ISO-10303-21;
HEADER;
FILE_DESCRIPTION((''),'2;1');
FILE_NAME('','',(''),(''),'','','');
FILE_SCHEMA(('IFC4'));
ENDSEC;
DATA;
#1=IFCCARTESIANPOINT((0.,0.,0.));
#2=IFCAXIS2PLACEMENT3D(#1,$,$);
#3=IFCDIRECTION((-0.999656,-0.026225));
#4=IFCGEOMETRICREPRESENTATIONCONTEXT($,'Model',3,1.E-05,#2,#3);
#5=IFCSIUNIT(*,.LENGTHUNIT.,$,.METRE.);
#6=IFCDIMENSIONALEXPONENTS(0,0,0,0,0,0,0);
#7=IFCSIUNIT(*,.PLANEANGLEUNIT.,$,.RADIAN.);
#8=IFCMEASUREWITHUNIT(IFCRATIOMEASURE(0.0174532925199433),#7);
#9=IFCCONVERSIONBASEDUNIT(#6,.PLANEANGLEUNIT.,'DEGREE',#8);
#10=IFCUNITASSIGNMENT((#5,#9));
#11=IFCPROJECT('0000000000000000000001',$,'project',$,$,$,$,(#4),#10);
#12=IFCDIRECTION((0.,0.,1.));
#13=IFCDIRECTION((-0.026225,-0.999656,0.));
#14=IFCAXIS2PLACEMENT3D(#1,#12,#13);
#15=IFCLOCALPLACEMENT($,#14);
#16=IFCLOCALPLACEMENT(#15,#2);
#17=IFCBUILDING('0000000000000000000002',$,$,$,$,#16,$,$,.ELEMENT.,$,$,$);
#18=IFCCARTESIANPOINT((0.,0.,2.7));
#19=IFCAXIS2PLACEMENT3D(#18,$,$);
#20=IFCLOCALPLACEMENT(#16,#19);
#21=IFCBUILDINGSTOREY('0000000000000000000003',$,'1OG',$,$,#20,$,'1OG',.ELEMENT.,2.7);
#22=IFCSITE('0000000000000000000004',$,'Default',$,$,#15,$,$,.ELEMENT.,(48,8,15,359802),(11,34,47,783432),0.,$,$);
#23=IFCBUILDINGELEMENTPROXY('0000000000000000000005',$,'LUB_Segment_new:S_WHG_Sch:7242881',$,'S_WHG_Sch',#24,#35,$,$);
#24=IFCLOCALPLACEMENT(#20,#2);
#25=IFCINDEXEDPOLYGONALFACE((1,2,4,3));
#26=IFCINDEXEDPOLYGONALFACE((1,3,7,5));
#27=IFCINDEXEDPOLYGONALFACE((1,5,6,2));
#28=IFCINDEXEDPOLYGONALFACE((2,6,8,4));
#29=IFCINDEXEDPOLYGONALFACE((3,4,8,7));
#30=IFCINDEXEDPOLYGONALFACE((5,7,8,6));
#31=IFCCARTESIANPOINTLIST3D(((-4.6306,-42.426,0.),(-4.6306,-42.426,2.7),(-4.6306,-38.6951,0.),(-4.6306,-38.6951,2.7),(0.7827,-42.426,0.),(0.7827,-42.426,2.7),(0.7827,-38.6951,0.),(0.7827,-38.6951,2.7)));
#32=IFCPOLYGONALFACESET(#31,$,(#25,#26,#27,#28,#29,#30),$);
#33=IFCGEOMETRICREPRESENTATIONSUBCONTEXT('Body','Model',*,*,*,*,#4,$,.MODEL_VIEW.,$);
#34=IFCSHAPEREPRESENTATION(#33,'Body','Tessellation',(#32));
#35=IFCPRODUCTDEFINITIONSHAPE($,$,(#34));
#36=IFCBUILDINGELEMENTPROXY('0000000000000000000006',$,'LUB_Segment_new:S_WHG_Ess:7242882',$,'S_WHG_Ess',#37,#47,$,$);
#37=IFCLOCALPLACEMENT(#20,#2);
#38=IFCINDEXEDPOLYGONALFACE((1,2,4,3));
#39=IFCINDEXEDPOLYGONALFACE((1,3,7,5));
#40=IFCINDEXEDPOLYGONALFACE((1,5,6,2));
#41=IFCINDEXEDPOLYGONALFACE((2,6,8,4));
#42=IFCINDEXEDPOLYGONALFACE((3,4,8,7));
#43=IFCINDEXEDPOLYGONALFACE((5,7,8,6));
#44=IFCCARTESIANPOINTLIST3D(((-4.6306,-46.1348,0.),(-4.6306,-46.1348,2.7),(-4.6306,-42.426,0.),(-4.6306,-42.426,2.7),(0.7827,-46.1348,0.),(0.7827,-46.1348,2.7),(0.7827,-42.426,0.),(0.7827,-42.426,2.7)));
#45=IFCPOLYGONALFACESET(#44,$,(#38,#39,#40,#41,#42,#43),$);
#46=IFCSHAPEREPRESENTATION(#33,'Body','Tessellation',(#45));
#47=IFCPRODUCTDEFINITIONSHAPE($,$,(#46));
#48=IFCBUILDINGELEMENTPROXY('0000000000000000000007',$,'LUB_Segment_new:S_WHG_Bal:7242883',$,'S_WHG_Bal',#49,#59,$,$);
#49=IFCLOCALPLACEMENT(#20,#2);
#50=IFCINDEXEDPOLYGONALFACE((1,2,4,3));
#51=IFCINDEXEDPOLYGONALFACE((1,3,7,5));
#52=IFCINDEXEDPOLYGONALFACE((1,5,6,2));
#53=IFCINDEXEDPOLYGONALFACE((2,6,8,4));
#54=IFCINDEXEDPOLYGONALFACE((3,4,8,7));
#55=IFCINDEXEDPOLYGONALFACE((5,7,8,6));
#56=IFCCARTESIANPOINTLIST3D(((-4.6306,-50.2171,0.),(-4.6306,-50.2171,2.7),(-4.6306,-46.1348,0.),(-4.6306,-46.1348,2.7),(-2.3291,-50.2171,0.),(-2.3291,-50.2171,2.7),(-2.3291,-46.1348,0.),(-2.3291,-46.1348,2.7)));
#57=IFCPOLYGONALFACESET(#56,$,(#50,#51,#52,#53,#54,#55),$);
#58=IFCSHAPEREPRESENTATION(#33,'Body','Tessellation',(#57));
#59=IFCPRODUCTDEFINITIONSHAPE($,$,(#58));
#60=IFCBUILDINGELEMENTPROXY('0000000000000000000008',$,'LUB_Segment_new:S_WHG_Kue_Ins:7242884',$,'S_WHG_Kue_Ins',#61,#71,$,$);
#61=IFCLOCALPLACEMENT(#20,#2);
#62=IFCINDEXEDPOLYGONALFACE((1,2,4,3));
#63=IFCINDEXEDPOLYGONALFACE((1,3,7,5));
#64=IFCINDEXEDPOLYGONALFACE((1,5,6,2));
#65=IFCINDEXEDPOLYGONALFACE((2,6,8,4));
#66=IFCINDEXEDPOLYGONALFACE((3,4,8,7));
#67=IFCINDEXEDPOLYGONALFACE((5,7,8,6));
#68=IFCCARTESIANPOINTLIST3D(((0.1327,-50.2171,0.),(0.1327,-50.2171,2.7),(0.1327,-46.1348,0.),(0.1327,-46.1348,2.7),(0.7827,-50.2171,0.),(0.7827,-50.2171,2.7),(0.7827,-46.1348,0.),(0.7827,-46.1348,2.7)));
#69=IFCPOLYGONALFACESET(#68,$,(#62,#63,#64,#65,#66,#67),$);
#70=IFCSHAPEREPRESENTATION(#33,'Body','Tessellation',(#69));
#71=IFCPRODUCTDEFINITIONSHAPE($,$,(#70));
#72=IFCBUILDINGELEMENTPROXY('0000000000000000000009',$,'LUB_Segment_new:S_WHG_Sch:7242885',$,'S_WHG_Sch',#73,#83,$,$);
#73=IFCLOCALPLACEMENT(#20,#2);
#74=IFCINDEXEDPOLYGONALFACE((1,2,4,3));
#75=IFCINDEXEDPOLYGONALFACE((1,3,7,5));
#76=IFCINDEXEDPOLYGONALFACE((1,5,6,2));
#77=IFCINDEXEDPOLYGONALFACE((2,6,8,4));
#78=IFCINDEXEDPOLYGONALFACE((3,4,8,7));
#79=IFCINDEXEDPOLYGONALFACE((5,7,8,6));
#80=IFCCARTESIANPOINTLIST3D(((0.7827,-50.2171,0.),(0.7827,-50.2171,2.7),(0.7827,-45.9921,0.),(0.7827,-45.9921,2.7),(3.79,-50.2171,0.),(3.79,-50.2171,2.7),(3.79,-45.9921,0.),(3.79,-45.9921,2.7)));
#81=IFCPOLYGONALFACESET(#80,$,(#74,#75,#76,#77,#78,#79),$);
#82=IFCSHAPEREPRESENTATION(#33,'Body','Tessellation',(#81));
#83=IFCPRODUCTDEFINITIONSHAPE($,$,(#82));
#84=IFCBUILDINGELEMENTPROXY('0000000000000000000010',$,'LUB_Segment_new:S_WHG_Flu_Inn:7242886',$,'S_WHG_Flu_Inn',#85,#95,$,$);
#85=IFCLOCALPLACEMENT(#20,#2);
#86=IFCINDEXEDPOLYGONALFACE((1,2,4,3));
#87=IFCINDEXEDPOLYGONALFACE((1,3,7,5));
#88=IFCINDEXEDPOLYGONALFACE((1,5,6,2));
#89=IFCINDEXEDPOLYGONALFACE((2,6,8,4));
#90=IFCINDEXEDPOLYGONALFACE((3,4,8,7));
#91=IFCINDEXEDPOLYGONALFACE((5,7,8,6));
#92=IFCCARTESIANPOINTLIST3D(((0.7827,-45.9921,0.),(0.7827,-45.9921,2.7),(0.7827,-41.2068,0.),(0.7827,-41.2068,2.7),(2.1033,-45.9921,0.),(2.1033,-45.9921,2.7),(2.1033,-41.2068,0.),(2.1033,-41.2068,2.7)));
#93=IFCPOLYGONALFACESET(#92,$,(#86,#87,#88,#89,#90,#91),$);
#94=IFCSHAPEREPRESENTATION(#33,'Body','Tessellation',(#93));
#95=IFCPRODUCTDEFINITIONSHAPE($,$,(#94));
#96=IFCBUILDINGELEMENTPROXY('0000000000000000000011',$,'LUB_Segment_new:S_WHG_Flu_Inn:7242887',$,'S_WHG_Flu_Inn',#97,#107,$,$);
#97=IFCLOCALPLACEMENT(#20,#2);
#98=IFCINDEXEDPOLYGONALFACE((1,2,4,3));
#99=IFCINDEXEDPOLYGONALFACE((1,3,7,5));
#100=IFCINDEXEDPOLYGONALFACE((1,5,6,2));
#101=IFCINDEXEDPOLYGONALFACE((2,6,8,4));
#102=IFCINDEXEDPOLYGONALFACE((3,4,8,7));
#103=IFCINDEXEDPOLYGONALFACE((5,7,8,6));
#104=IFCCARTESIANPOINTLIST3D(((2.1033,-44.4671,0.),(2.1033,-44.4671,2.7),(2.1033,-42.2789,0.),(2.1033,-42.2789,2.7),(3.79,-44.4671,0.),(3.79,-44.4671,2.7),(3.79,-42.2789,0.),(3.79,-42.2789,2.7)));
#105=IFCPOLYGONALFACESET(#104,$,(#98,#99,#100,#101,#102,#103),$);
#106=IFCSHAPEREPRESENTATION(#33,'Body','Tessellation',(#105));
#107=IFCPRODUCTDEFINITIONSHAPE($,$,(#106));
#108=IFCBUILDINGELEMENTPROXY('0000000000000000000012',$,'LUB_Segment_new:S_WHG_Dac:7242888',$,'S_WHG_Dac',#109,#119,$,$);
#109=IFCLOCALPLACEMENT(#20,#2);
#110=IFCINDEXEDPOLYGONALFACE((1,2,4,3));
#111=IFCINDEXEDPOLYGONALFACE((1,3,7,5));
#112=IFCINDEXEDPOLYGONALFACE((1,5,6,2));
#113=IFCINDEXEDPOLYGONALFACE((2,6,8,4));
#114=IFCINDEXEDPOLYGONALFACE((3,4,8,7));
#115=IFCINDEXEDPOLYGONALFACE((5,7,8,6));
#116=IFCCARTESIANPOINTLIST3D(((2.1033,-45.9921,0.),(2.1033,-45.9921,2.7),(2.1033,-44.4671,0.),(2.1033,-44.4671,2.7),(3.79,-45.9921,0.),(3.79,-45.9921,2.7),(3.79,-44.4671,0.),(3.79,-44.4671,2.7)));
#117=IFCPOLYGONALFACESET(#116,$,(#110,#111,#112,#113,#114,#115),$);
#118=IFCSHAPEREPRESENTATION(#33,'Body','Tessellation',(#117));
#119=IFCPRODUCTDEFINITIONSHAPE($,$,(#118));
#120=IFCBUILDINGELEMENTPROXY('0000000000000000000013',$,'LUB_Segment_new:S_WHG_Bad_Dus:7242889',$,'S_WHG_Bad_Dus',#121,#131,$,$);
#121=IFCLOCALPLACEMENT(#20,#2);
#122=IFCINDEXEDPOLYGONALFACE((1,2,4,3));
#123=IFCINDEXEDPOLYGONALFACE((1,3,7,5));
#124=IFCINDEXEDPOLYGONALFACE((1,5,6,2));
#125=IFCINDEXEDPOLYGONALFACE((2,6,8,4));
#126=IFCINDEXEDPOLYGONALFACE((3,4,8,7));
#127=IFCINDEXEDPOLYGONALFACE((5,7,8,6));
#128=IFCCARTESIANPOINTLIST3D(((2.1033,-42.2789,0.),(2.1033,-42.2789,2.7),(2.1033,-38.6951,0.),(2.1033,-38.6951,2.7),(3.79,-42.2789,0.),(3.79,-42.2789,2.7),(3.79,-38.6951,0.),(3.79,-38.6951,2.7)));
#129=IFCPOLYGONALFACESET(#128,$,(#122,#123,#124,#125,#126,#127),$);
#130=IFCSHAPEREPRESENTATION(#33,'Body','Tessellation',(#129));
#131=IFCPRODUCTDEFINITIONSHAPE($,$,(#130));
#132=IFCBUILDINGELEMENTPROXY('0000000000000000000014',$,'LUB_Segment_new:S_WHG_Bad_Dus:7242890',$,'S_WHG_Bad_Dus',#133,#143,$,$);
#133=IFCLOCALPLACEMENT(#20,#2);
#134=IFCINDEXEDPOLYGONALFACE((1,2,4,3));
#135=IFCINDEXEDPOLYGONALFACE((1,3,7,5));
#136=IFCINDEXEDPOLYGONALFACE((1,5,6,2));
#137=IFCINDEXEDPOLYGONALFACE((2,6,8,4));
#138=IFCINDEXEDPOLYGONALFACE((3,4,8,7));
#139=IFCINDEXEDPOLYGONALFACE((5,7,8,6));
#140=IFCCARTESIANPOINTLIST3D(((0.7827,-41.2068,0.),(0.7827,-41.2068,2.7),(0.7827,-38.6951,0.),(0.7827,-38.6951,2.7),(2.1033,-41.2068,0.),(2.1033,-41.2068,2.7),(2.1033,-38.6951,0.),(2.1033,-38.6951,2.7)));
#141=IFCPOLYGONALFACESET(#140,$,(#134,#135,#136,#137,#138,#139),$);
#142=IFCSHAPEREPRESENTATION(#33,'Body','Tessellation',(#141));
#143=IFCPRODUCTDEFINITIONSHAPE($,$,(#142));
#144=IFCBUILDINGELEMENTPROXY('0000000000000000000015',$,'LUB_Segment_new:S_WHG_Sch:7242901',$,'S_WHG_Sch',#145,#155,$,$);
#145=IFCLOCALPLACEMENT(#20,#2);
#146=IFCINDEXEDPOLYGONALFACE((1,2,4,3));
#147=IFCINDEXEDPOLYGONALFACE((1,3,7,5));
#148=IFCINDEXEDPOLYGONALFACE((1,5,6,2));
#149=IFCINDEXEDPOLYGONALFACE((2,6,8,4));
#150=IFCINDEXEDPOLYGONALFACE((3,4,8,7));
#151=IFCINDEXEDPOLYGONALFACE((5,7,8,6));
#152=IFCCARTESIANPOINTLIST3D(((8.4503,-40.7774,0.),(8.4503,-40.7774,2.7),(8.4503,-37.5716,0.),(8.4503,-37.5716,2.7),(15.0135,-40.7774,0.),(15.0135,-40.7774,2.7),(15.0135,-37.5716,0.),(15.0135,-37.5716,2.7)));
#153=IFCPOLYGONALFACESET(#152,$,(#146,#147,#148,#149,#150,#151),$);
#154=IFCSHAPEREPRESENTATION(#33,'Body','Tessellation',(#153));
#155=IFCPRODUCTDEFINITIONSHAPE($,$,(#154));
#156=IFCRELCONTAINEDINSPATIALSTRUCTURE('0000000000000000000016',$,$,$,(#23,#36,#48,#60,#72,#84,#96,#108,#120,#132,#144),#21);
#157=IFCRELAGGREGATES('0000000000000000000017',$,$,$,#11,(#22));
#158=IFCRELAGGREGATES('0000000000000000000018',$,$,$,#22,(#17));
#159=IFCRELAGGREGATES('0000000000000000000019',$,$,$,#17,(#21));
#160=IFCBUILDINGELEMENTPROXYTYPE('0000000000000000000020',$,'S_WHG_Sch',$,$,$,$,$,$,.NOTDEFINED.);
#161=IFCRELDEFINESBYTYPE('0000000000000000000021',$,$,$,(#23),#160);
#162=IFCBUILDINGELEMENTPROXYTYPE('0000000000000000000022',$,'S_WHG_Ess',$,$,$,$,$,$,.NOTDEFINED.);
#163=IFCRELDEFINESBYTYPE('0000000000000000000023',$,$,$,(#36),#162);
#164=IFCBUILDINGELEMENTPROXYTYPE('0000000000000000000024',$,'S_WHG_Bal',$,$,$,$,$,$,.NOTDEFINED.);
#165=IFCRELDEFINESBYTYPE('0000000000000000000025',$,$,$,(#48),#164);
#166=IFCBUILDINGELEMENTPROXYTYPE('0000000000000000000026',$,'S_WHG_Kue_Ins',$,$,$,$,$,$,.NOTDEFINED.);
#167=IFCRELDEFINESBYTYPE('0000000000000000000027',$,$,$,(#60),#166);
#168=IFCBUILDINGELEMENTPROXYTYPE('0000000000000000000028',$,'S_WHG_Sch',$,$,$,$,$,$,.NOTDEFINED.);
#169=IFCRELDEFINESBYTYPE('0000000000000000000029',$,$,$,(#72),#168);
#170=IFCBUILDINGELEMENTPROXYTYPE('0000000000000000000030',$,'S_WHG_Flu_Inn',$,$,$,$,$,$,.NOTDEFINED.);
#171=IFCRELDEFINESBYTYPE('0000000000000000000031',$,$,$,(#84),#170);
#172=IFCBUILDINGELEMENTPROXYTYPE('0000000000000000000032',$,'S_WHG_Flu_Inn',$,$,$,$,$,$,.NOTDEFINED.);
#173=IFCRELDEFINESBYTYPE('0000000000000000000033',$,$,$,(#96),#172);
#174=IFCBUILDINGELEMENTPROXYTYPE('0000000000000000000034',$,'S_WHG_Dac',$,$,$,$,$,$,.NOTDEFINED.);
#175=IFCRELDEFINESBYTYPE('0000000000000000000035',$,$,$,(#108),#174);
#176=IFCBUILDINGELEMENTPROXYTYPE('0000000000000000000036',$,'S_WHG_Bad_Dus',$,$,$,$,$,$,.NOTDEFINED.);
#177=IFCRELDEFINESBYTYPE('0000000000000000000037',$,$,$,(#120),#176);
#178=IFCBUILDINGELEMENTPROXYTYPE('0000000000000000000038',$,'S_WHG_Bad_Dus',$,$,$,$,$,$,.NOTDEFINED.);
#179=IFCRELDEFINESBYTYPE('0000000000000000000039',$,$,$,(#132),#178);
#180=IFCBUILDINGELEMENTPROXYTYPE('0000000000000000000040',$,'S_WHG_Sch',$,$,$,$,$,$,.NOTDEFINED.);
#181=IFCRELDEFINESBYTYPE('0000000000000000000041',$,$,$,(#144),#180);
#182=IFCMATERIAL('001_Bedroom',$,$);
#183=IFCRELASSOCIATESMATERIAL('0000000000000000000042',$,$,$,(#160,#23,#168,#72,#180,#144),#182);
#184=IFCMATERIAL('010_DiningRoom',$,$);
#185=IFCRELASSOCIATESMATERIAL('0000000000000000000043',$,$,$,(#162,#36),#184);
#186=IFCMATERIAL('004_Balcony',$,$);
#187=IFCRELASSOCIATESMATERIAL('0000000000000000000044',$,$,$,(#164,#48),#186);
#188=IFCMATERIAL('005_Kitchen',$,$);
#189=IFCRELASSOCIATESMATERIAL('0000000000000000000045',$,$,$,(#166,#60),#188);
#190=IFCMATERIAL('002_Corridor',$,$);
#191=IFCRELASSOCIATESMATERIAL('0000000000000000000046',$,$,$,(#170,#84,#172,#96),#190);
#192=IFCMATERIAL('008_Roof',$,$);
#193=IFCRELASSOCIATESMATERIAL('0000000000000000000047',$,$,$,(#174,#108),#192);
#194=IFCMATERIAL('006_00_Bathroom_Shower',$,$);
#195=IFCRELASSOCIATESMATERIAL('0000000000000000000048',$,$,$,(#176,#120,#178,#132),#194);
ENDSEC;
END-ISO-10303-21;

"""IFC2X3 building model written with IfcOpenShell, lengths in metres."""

from ifc_helpers import new_model, entity, si_unit, converted_unit, direction, frame, frame_2d, origin, origin_2d_with_axis, place, context, subcontext, project, spatial, rectangle, extrude, source, transform, mapped, material, type_object, type_shapes, element, save


model = new_model("IFC2X3")

# Units and contexts
model_context = context("Model", 3, precision=1e-05, world=origin(), true_north=direction((-0.999656, -0.026225)))
body_context = subcontext(model_context, "Body", "Model", "MODEL_VIEW")
ifc_project = project(units=[si_unit("LENGTHUNIT", "METRE"), converted_unit("PLANEANGLEUNIT", "DEGREE", entity("IfcRatioMeasure", 0.0174532925199433), si_unit("PLANEANGLEUNIT", "RADIAN"), dimensions=[0, 0, 0, 0, 0, 0, 0])], contexts=[model_context])

# Site, building, storey
site_placement = place(None, frame((0.0, 0.0, 0.0), z_axis=(0.0, 0.0, 1.0), x_axis=(-0.026225, -0.999656, 0.0)))
site = spatial("IfcSite", under=ifc_project, at=site_placement, Name="Default", CompositionType="ELEMENT", RefLatitude=(48, 8, 15, 359802), RefLongitude=(11, 34, 47, 783432), RefElevation=0.0)
building_placement = place(site_placement, origin())
building = spatial("IfcBuilding", under=site, at=building_placement, CompositionType="ELEMENT")
storey_placement = place(building_placement, frame((0.0, 0.0, 2.7)))
storey = spatial("IfcBuildingStorey", under=building, at=storey_placement, Name="1OG", LongName="1OG", CompositionType="ELEMENT", Elevation=2.7)

# Building element proxies
ifc_material_1 = material(Name="001_Bedroom")
building_element_proxy_type_1 = type_object("IfcBuildingElementProxyType", Name="S_WHG_Sch", PredefinedType="NOTDEFINED", material=ifc_material_1)
shared_shape_1 = source(origin(), body_context, "Body", "SweptSolid", [
    extrude(rectangle(XDim=5.4132, YDim=3.7309, at=origin_2d_with_axis()), frame((0.0, 0.0, 0.0), z_axis=(0.0, 0.0, 1.0), x_axis=(-1.0, 0.0, 0.0)), (0.0, 0.0, 1.0), 2.7),
])
type_shapes(building_element_proxy_type_1, [shared_shape_1])
proxy_1_placement = place(storey_placement, frame((-1.924, -40.5605, 0.0)))
element("IfcBuildingElementProxy", 1, at=proxy_1_placement, inside=storey, type_object=building_element_proxy_type_1, material=ifc_material_1, Name="LUB_Segment_new:S_WHG_Sch:7242881", ObjectType="S_WHG_Sch", context=body_context, shape_type="MappedRepresentation", body=[
    mapped(shared_shape_1, transform((0.0, 0.0, 0.0), scale=1.0)),
])
ifc_material_2 = material(Name="010_DiningRoom")
building_element_proxy_type_2 = type_object("IfcBuildingElementProxyType", Name="S_WHG_Ess", PredefinedType="NOTDEFINED", material=ifc_material_2)
shared_shape_2 = source(origin(), body_context, "Body", "SweptSolid", [
    extrude(rectangle(XDim=5.4132, YDim=3.7088, at=origin_2d_with_axis()), frame((0.0, 0.0, 0.0), z_axis=(0.0, 0.0, 1.0), x_axis=(-1.0, 0.0, 0.0)), (0.0, 0.0, 1.0), 2.7),
])
type_shapes(building_element_proxy_type_2, [shared_shape_2])
proxy_2_placement = place(storey_placement, frame((-1.924, -44.2804, 0.0)))
element("IfcBuildingElementProxy", 2, at=proxy_2_placement, inside=storey, type_object=building_element_proxy_type_2, material=ifc_material_2, Name="LUB_Segment_new:S_WHG_Ess:7242882", ObjectType="S_WHG_Ess", context=body_context, shape_type="MappedRepresentation", body=[
    mapped(shared_shape_2, transform((0.0, 0.0, 0.0), scale=1.0)),
])
ifc_material_3 = material(Name="004_Balcony")
building_element_proxy_type_3 = type_object("IfcBuildingElementProxyType", Name="S_WHG_Bal", PredefinedType="NOTDEFINED", material=ifc_material_3)
shared_shape_3 = source(origin(), body_context, "Body", "SweptSolid", [
    extrude(rectangle(XDim=4.0824, YDim=2.3015, at=origin_2d_with_axis()), frame((0.0, 0.0, 0.0), z_axis=(0.0, 0.0, 1.0), x_axis=(0.0, 1.0, 0.0)), (0.0, 0.0, 1.0), 2.7),
])
type_shapes(building_element_proxy_type_3, [shared_shape_3])
proxy_3_placement = place(storey_placement, frame((-3.4798, -48.176, 0.0)))
element("IfcBuildingElementProxy", 3, at=proxy_3_placement, inside=storey, type_object=building_element_proxy_type_3, material=ifc_material_3, Name="LUB_Segment_new:S_WHG_Bal:7242883", ObjectType="S_WHG_Bal", context=body_context, shape_type="MappedRepresentation", body=[
    mapped(shared_shape_3, transform((0.0, 0.0, 0.0), scale=1.0)),
])
ifc_material_4 = material(Name="005_Kitchen")
building_element_proxy_type_4 = type_object("IfcBuildingElementProxyType", Name="S_WHG_Kue_Ins", PredefinedType="NOTDEFINED", material=ifc_material_4)
shared_shape_4 = source(origin(), body_context, "Body", "SweptSolid", [
    extrude(rectangle(XDim=4.0824, YDim=0.65, at=origin_2d_with_axis()), frame((0.0, 0.0, 0.0), z_axis=(0.0, 0.0, 1.0), x_axis=(0.0, 1.0, 0.0)), (0.0, 0.0, 1.0), 2.7),
])
type_shapes(building_element_proxy_type_4, [shared_shape_4])
proxy_4_placement = place(storey_placement, frame((0.4577, -48.176, 0.0)))
element("IfcBuildingElementProxy", 4, at=proxy_4_placement, inside=storey, type_object=building_element_proxy_type_4, material=ifc_material_4, Name="LUB_Segment_new:S_WHG_Kue_Ins:7242884", ObjectType="S_WHG_Kue_Ins", context=body_context, shape_type="MappedRepresentation", body=[
    mapped(shared_shape_4, transform((0.0, 0.0, 0.0), scale=1.0)),
])
building_element_proxy_type_5 = type_object("IfcBuildingElementProxyType", Name="S_WHG_Sch", PredefinedType="NOTDEFINED", material=ifc_material_1)
shared_shape_5 = source(origin(), body_context, "Body", "SweptSolid", [
    extrude(rectangle(XDim=4.225, YDim=3.0074, at=origin_2d_with_axis()), frame((0.0, 0.0, 0.0), z_axis=(0.0, 0.0, 1.0), x_axis=(0.0, 1.0, 0.0)), (0.0, 0.0, 1.0), 2.7),
])
type_shapes(building_element_proxy_type_5, [shared_shape_5])
proxy_5_placement = place(storey_placement, frame((2.2863, -48.1046, 0.0)))
element("IfcBuildingElementProxy", 5, at=proxy_5_placement, inside=storey, type_object=building_element_proxy_type_5, material=ifc_material_1, Name="LUB_Segment_new:S_WHG_Sch:7242885", ObjectType="S_WHG_Sch", context=body_context, shape_type="MappedRepresentation", body=[
    mapped(shared_shape_5, transform((0.0, 0.0, 0.0), scale=1.0)),
])
ifc_material_5 = material(Name="002_Corridor")
building_element_proxy_type_6 = type_object("IfcBuildingElementProxyType", Name="S_WHG_Flu_Inn", PredefinedType="NOTDEFINED", material=ifc_material_5)
shared_shape_6 = source(origin(), body_context, "Body", "SweptSolid", [
    extrude(rectangle(XDim=4.7853, YDim=1.3206, at=origin_2d_with_axis()), frame((0.0, 0.0, 0.0), z_axis=(0.0, 0.0, 1.0), x_axis=(0.0, 1.0, 0.0)), (0.0, 0.0, 1.0), 2.7),
])
type_shapes(building_element_proxy_type_6, [shared_shape_6])
proxy_6_placement = place(storey_placement, frame((1.443, -43.5995, 0.0)))
element("IfcBuildingElementProxy", 6, at=proxy_6_placement, inside=storey, type_object=building_element_proxy_type_6, material=ifc_material_5, Name="LUB_Segment_new:S_WHG_Flu_Inn:7242886", ObjectType="S_WHG_Flu_Inn", context=body_context, shape_type="MappedRepresentation", body=[
    mapped(shared_shape_6, transform((0.0, 0.0, 0.0), scale=1.0)),
])
building_element_proxy_type_7 = type_object("IfcBuildingElementProxyType", Name="S_WHG_Flu_Inn", PredefinedType="NOTDEFINED", material=ifc_material_5)
shared_shape_7 = source(origin(), body_context, "Body", "SweptSolid", [
    extrude(rectangle(XDim=2.1882, YDim=1.6868, at=origin_2d_with_axis()), frame((0.0, 0.0, 0.0), z_axis=(0.0, 0.0, 1.0), x_axis=(0.0, 1.0, 0.0)), (0.0, 0.0, 1.0), 2.7),
])
type_shapes(building_element_proxy_type_7, [shared_shape_7])
proxy_7_placement = place(storey_placement, frame((2.9466, -43.373, 0.0)))
element("IfcBuildingElementProxy", 7, at=proxy_7_placement, inside=storey, type_object=building_element_proxy_type_7, material=ifc_material_5, Name="LUB_Segment_new:S_WHG_Flu_Inn:7242887", ObjectType="S_WHG_Flu_Inn", context=body_context, shape_type="MappedRepresentation", body=[
    mapped(shared_shape_7, transform((0.0, 0.0, 0.0), scale=1.0)),
])
ifc_material_6 = material(Name="008_Roof")
building_element_proxy_type_8 = type_object("IfcBuildingElementProxyType", Name="S_WHG_Dac", PredefinedType="NOTDEFINED", material=ifc_material_6)
shared_shape_8 = source(origin(), body_context, "Body", "SweptSolid", [
    extrude(rectangle(XDim=1.525, YDim=1.6868, at=origin_2d_with_axis()), frame((0.0, 0.0, 0.0), z_axis=(0.0, 0.0, 1.0), x_axis=(0.0, 1.0, 0.0)), (0.0, 0.0, 1.0), 2.7),
])
type_shapes(building_element_proxy_type_8, [shared_shape_8])
proxy_8_placement = place(storey_placement, frame((2.9466, -45.2296, 0.0)))
element("IfcBuildingElementProxy", 8, at=proxy_8_placement, inside=storey, type_object=building_element_proxy_type_8, material=ifc_material_6, Name="LUB_Segment_new:S_WHG_Dac:7242888", ObjectType="S_WHG_Dac", context=body_context, shape_type="MappedRepresentation", body=[
    mapped(shared_shape_8, transform((0.0, 0.0, 0.0), scale=1.0)),
])
ifc_material_7 = material(Name="006_00_Bathroom_Shower")
building_element_proxy_type_9 = type_object("IfcBuildingElementProxyType", Name="S_WHG_Bad_Dus", PredefinedType="NOTDEFINED", material=ifc_material_7)
shared_shape_9 = source(origin(), body_context, "Body", "SweptSolid", [
    extrude(rectangle(XDim=3.5838, YDim=1.6868, at=origin_2d_with_axis()), frame((0.0, 0.0, 0.0), z_axis=(0.0, 0.0, 1.0), x_axis=(0.0, 1.0, 0.0)), (0.0, 0.0, 1.0), 2.7),
])
type_shapes(building_element_proxy_type_9, [shared_shape_9])
proxy_9_placement = place(storey_placement, frame((2.9466, -40.487, 0.0)))
element("IfcBuildingElementProxy", 9, at=proxy_9_placement, inside=storey, type_object=building_element_proxy_type_9, material=ifc_material_7, Name="LUB_Segment_new:S_WHG_Bad_Dus:7242889", ObjectType="S_WHG_Bad_Dus", context=body_context, shape_type="MappedRepresentation", body=[
    mapped(shared_shape_9, transform((0.0, 0.0, 0.0), scale=1.0)),
])
building_element_proxy_type_10 = type_object("IfcBuildingElementProxyType", Name="S_WHG_Bad_Dus", PredefinedType="NOTDEFINED", material=ifc_material_7)
shared_shape_10 = source(origin(), body_context, "Body", "SweptSolid", [
    extrude(rectangle(XDim=2.5118, YDim=1.3206, at=frame_2d((0.0, 0.0), x_axis=(1.0, 0.0))), frame((0.0, 0.0, 0.0), z_axis=(0.0, 0.0, 1.0), x_axis=(0.0, 1.0, 0.0)), (0.0, 0.0, 1.0), 2.7),
])
type_shapes(building_element_proxy_type_10, [shared_shape_10])
proxy_10_placement = place(storey_placement, frame((1.443, -39.951, 0.0)))
element("IfcBuildingElementProxy", 10, at=proxy_10_placement, inside=storey, type_object=building_element_proxy_type_10, material=ifc_material_7, Name="LUB_Segment_new:S_WHG_Bad_Dus:7242890", ObjectType="S_WHG_Bad_Dus", context=body_context, shape_type="MappedRepresentation", body=[
    mapped(shared_shape_10, transform((0.0, 0.0, 0.0), scale=1.0)),
])
building_element_proxy_type_11 = type_object("IfcBuildingElementProxyType", Name="S_WHG_Sch", PredefinedType="NOTDEFINED", material=ifc_material_1)
shared_shape_11 = source(origin(), body_context, "Body", "SweptSolid", [
    extrude(rectangle(XDim=6.5632, YDim=3.2059, at=origin_2d_with_axis()), frame((0.0, 0.0, 0.0), z_axis=(0.0, 0.0, 1.0), x_axis=(-1.0, 0.0, 0.0)), (0.0, 0.0, 1.0), 2.7),
])
type_shapes(building_element_proxy_type_11, [shared_shape_11])
proxy_11_placement = place(storey_placement, frame((11.7319, -39.1745, 0.0)))
element("IfcBuildingElementProxy", 11, at=proxy_11_placement, inside=storey, type_object=building_element_proxy_type_11, material=ifc_material_1, Name="LUB_Segment_new:S_WHG_Sch:7242901", ObjectType="S_WHG_Sch", context=body_context, shape_type="MappedRepresentation", body=[
    mapped(shared_shape_11, transform((0.0, 0.0, 0.0), scale=1.0)),
])

save(model, "model.ifc")
